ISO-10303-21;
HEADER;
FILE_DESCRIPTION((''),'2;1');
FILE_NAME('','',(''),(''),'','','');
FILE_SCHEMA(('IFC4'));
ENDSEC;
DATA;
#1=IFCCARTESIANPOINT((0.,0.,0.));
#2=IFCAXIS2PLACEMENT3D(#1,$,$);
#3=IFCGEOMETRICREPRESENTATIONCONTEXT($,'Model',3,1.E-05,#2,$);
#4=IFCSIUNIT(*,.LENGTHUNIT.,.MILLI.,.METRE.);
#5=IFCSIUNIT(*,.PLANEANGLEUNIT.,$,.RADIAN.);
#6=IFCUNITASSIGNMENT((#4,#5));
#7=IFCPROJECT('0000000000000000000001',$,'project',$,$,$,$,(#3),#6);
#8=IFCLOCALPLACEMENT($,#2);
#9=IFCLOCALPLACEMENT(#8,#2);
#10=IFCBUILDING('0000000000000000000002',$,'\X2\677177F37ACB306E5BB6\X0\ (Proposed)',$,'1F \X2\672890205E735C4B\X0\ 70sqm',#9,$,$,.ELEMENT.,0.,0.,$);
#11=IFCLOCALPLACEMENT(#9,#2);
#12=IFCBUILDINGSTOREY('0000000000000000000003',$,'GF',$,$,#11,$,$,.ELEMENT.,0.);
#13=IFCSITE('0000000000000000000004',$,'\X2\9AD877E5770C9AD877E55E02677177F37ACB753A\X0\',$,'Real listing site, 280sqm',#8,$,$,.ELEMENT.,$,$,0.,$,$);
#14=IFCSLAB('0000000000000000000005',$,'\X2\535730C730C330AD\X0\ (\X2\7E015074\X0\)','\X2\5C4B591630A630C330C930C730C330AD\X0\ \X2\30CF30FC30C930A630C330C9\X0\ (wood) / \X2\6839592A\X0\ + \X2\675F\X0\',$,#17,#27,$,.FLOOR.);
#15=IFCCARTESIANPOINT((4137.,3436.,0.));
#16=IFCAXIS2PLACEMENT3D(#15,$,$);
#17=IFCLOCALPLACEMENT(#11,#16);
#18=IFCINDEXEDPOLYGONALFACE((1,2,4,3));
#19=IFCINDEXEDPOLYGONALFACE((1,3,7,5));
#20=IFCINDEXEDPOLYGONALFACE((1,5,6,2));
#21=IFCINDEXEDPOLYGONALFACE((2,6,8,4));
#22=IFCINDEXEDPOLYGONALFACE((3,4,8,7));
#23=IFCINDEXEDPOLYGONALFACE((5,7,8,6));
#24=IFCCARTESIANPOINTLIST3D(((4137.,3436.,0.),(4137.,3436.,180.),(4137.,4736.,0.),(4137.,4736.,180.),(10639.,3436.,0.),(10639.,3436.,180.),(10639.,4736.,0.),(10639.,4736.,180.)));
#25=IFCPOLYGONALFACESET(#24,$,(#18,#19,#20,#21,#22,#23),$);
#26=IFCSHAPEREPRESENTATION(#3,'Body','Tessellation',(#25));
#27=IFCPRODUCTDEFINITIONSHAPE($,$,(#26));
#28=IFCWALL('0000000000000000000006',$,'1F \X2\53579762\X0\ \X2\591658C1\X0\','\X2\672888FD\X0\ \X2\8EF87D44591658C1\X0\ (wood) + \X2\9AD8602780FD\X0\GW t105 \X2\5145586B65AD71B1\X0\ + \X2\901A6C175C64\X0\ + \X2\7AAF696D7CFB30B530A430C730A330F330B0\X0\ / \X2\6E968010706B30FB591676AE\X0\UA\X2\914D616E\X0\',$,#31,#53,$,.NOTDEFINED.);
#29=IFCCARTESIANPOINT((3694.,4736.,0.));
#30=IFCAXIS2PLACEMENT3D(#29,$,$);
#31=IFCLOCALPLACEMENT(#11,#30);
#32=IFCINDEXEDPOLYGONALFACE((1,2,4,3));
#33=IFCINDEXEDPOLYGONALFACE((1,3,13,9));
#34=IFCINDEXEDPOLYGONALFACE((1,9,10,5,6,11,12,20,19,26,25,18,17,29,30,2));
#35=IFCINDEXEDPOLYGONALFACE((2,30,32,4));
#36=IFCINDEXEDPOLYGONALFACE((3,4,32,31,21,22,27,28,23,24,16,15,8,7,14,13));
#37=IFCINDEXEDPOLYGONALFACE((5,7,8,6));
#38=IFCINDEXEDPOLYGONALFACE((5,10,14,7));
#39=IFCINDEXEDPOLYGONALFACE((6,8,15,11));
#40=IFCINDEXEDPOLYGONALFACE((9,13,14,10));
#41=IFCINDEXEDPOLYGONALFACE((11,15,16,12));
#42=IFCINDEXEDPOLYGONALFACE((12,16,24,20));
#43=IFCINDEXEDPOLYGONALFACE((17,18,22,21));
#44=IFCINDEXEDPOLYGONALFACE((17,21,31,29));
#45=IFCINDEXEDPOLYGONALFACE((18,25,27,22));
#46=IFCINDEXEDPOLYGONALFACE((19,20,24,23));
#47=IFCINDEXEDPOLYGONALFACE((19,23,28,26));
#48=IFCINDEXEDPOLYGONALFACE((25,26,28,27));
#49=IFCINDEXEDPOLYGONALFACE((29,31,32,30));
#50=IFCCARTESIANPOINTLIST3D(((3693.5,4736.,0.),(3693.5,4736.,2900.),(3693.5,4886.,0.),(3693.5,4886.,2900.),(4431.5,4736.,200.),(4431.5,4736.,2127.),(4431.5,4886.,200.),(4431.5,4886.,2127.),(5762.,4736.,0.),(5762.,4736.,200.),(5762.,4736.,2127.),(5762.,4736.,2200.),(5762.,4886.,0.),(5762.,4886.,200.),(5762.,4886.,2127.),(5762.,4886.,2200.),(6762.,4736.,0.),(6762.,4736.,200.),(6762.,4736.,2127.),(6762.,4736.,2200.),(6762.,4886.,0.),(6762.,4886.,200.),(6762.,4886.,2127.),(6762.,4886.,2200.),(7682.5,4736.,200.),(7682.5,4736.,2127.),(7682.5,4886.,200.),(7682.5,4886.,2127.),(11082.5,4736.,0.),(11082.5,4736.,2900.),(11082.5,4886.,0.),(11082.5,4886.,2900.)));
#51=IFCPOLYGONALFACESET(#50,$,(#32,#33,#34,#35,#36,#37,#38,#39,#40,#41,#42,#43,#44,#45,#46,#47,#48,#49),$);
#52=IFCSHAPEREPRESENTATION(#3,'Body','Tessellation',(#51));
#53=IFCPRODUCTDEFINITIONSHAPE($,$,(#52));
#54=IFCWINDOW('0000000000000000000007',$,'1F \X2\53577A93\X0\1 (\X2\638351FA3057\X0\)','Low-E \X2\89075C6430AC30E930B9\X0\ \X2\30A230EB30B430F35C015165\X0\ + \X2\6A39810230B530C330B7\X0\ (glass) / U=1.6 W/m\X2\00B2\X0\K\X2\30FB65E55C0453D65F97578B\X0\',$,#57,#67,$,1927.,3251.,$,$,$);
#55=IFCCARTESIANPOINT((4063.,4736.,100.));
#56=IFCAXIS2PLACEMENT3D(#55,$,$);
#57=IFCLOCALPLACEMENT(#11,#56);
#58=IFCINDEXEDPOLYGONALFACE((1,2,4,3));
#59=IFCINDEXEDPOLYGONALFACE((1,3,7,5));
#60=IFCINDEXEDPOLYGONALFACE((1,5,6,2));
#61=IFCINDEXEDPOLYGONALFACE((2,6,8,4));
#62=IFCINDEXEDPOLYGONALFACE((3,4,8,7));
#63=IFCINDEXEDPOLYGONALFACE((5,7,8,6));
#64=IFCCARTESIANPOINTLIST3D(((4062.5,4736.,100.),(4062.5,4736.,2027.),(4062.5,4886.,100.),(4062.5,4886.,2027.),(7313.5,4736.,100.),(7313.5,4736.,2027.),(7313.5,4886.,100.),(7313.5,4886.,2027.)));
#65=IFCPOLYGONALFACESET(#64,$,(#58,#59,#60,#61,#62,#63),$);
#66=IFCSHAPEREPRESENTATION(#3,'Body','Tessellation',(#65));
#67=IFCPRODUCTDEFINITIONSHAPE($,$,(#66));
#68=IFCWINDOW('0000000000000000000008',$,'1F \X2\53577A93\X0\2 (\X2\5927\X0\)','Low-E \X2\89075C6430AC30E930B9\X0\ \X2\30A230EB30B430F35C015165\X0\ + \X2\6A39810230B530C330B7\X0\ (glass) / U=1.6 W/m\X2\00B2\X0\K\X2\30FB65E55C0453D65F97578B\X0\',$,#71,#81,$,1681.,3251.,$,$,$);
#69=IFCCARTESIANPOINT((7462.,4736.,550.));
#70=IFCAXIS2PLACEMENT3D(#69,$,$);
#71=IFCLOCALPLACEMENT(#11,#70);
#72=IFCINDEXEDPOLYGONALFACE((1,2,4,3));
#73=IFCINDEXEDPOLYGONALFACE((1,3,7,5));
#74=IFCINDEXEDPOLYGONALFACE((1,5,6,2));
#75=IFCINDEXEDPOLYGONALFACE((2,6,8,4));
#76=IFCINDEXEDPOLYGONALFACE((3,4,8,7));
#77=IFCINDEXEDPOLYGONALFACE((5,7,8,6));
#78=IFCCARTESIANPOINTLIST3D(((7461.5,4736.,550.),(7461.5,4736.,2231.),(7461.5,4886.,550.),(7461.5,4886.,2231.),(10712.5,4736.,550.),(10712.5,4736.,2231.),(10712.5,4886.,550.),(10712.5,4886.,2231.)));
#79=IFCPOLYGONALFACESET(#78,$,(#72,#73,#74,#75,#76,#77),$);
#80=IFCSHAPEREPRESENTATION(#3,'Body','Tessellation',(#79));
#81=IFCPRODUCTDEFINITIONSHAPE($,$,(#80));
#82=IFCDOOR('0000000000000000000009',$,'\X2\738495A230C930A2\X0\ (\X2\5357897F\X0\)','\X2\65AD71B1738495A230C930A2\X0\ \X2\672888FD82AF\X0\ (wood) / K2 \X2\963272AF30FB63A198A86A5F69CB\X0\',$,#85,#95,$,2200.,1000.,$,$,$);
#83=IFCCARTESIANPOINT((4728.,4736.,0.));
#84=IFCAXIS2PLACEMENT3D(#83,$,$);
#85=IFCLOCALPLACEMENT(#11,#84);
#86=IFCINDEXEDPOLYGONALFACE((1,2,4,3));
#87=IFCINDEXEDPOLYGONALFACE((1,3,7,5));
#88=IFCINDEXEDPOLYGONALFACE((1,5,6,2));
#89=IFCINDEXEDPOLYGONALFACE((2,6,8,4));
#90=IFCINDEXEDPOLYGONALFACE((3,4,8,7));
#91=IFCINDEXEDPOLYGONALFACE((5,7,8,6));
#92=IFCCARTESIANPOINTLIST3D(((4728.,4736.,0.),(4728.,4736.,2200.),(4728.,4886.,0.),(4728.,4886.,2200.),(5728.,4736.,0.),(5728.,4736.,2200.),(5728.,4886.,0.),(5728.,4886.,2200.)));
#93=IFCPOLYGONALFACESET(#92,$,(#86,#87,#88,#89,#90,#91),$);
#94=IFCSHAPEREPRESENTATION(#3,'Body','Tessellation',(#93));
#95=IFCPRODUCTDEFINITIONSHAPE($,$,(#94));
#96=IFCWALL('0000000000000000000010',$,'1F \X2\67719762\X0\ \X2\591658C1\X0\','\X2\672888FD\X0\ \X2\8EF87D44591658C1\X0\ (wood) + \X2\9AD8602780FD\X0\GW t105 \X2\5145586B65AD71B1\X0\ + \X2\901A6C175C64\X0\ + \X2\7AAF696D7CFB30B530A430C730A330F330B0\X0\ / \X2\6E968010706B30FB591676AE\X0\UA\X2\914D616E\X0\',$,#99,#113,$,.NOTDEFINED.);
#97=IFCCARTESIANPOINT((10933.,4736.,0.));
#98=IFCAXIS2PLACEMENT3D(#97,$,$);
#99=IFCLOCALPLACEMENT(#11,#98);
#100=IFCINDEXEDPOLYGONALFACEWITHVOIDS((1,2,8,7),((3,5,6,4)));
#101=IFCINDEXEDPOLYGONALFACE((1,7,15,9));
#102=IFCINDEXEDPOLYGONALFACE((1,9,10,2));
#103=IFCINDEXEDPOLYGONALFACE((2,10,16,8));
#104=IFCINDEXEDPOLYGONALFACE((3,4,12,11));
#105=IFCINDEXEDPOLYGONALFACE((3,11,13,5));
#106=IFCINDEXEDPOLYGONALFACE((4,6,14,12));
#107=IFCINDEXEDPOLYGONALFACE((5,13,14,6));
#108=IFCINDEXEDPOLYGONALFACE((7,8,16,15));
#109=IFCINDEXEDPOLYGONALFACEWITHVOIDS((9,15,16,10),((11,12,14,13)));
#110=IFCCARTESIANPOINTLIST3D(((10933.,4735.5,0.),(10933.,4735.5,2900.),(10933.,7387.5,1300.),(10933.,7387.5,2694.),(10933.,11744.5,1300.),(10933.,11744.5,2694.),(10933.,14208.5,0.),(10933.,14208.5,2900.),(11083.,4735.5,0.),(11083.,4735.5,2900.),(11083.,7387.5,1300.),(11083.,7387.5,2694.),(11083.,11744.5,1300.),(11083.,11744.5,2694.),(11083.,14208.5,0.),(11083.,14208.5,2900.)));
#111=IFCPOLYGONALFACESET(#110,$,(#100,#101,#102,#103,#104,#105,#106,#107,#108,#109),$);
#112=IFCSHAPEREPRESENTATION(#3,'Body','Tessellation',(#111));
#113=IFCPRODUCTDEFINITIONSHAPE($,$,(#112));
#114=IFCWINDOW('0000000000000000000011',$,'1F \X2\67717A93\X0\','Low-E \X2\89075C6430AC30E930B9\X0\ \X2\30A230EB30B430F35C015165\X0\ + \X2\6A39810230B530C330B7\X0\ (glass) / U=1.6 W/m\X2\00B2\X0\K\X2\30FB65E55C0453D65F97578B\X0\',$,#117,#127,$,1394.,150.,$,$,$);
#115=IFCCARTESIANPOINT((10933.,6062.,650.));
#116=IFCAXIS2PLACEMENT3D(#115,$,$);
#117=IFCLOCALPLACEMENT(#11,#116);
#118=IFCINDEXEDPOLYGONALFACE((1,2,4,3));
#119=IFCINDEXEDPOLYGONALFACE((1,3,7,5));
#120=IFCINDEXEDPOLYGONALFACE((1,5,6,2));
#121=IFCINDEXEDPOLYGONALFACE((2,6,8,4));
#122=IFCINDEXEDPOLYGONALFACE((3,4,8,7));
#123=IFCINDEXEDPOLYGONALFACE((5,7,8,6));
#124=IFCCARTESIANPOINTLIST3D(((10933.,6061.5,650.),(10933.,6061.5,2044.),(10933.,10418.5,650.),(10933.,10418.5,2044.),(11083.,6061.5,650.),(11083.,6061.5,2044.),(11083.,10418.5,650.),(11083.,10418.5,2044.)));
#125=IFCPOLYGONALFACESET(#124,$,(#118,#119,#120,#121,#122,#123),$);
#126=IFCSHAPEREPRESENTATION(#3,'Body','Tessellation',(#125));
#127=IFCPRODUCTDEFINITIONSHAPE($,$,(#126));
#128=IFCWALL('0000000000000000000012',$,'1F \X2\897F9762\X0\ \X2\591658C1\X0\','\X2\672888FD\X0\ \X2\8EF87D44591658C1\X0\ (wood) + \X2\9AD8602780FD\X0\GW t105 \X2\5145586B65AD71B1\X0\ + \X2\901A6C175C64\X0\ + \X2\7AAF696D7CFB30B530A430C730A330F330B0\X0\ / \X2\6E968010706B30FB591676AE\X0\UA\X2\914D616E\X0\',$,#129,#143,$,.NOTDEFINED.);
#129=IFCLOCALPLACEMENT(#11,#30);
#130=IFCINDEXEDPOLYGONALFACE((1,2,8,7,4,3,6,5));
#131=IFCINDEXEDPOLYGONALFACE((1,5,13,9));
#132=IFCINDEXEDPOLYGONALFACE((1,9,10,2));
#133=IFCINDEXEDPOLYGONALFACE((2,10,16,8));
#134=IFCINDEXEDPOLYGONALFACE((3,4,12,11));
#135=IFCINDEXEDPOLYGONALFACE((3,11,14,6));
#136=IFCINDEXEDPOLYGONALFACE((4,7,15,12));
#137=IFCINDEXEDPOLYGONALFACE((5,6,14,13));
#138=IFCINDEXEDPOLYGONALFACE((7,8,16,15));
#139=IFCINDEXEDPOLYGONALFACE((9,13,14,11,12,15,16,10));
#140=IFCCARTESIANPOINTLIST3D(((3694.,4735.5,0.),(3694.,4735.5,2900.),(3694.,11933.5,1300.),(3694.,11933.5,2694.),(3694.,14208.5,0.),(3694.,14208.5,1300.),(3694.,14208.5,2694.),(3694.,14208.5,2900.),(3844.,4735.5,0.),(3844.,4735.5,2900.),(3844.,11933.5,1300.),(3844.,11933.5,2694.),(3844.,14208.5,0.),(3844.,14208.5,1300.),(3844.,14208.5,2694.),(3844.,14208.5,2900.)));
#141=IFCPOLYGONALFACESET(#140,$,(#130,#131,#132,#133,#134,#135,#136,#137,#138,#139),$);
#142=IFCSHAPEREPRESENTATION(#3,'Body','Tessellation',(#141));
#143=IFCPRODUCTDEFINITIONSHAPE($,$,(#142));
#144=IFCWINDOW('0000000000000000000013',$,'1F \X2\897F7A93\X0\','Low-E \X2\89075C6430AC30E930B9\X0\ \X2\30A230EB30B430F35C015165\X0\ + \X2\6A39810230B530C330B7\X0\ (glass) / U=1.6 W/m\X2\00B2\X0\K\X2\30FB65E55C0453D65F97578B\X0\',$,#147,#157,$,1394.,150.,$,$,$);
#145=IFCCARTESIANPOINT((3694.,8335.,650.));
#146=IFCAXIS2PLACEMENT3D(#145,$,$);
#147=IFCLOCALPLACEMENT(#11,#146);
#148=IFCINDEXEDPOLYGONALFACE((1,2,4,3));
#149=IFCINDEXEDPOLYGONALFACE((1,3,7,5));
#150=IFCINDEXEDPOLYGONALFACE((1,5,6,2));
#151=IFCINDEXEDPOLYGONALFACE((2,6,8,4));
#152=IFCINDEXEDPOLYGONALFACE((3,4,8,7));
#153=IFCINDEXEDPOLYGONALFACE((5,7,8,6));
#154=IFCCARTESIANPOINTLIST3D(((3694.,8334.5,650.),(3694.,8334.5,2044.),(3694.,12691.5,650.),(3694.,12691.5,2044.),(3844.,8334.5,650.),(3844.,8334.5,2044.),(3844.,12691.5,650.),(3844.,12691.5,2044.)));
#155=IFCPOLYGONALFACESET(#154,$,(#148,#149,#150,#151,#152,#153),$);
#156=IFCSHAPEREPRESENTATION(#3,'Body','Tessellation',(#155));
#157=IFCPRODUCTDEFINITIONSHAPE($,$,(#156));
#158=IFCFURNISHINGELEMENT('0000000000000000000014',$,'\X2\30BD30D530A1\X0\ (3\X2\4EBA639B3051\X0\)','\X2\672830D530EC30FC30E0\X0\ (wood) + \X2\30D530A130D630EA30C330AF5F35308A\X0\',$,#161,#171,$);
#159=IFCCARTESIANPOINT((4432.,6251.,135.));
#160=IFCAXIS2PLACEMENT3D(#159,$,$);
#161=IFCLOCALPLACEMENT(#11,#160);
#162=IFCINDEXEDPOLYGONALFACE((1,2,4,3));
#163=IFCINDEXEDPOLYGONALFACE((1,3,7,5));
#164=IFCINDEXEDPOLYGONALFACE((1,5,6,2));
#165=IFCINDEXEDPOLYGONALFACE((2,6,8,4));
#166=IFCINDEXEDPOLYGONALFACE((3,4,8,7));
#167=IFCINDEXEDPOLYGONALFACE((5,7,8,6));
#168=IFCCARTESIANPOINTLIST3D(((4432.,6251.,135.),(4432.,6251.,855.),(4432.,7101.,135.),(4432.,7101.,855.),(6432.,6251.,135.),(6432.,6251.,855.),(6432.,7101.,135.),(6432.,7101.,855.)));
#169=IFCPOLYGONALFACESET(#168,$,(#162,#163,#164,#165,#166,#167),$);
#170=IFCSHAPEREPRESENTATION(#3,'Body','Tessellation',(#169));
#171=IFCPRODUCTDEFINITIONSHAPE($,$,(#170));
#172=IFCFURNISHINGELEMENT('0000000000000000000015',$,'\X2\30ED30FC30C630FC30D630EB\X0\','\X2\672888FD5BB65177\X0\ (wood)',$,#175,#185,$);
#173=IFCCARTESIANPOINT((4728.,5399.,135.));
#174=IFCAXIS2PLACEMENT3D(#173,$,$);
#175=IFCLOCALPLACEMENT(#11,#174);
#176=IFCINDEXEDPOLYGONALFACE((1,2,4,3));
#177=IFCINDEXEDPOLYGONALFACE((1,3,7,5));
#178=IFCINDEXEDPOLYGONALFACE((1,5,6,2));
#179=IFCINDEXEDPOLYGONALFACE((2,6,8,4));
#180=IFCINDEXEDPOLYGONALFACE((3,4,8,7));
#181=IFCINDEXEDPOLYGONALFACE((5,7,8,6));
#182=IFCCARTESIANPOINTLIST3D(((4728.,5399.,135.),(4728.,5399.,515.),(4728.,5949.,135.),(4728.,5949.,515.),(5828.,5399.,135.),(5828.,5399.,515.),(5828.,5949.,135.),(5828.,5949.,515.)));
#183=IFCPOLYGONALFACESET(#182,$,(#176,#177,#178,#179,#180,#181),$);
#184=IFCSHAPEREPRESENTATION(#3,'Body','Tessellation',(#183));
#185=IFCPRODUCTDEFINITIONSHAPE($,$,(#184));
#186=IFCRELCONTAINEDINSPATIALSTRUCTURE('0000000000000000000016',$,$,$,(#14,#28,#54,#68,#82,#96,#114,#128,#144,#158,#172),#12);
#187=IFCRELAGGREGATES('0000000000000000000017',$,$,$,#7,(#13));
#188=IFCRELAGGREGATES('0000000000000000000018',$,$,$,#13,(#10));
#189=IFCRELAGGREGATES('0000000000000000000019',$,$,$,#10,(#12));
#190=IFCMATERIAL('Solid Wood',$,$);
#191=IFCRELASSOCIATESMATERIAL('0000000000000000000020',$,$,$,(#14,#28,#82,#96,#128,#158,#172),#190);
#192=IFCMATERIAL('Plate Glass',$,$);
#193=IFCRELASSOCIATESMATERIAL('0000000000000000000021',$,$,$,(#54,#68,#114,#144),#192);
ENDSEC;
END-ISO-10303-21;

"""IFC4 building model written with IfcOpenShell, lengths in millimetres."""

from ifc_helpers import new_model, si_unit, frame, frame_2d, origin, place, context, project, spatial, rectangle, extrude, material, element, fill, save


model = new_model("IFC4")

# Units and contexts
model_context = context("Model", 3, precision=1e-05, world=origin())
ifc_project = project(units=[si_unit("LENGTHUNIT", "METRE", prefix="MILLI"), si_unit("PLANEANGLEUNIT", "RADIAN")], contexts=[model_context])

# Site, building, storey
site_placement = place(None, origin())
site = spatial("IfcSite", under=ifc_project, at=site_placement, Name="高知県高知市東石立町", ObjectType="Real listing site, 280sqm", CompositionType="ELEMENT", RefElevation=0.0)
building_placement = place(site_placement, origin())
building = spatial("IfcBuilding", under=site, at=building_placement, Name="東石立の家 (Proposed)", ObjectType="1F 木造平屋 70sqm", CompositionType="ELEMENT", ElevationOfRefHeight=0.0, ElevationOfTerrain=0.0)
storey_placement = place(building_placement, origin())
storey = spatial("IfcBuildingStorey", under=building, at=storey_placement, Name="GF", CompositionType="ELEMENT", Elevation=0.0)

# Slab
ifc_material_1 = material(Name="Solid Wood")
slab_1_placement = place(storey_placement, frame((4137.0, 3436.0, 0.0)))
element("IfcSlab", 1, at=slab_1_placement, inside=storey, material=ifc_material_1, Name="南デッキ (縁側)", Description="屋外ウッドデッキ ハードウッド (wood) / 根太 + 束", PredefinedType="FLOOR", context=model_context, shape_type="SweptSolid", body=[
    extrude(rectangle(XDim=6502.0, YDim=1300.0, at=frame_2d((3251.0, 650.0))), frame((4137.0, 3436.0, 0.0)), (0.0, 0.0, 1.0), 180.0),
])

# Wall, openings, windows, door
wall_1_placement = place(storey_placement, frame((3694.0, 4736.0, 0.0)))
wall_1 = element("IfcWall", 2, at=wall_1_placement, inside=storey, material=ifc_material_1, Name="1F 南面 外壁", Description="木製 軸組外壁 (wood) + 高性能GW t105 充填断熱 + 通気層 + 窯業系サイディング / 準耐火・外皮UA配慮", PredefinedType="NOTDEFINED", context=model_context, shape_type="SweptSolid", body=[
    extrude(rectangle(XDim=7389.0, YDim=150.0, at=frame_2d((3694.0, 75.0))), frame((3694.0, 4736.0, 0.0)), (0.0, 0.0, 1.0), 2900.0),
])
opening_1_placement = place(storey_placement, frame((4063.0, 4736.0, 100.0)))
opening_1 = element("IfcOpeningElement", 3, at=opening_1_placement, cuts=wall_1, PredefinedType="NOTDEFINED", context=model_context, shape_type="SweptSolid", body=[
    extrude(rectangle(XDim=3251.0, YDim=150.0, at=frame_2d((1625.0, 75.0))), frame((4063.0, 4736.0, 100.0)), (0.0, 0.0, 1.0), 1927.0),
])
opening_2_placement = place(storey_placement, frame((7462.0, 4736.0, 550.0)))
opening_2 = element("IfcOpeningElement", 4, at=opening_2_placement, cuts=wall_1, PredefinedType="NOTDEFINED", context=model_context, shape_type="SweptSolid", body=[
    extrude(rectangle(XDim=3251.0, YDim=150.0, at=frame_2d((1625.0, 75.0))), frame((7462.0, 4736.0, 550.0)), (0.0, 0.0, 1.0), 1681.0),
])
opening_3_placement = place(storey_placement, frame((4728.0, 4736.0, 0.0)))
opening_3 = element("IfcOpeningElement", 5, at=opening_3_placement, cuts=wall_1, PredefinedType="NOTDEFINED", context=model_context, shape_type="SweptSolid", body=[
    extrude(rectangle(XDim=1000.0, YDim=150.0, at=frame_2d((500.0, 75.0))), frame((4728.0, 4736.0, 0.0)), (0.0, 0.0, 1.0), 2200.0),
])
ifc_material_2 = material(Name="Plate Glass")
window_1_placement = place(storey_placement, frame((4063.0, 4736.0, 100.0)))
window_1 = element("IfcWindow", 6, at=window_1_placement, inside=storey, material=ifc_material_2, Name="1F 南窓1 (掃出し)", Description="Low-E 複層ガラス アルゴン封入 + 樹脂サッシ (glass) / U=1.6 W/m²K・日射取得型", OverallHeight=1927.0, OverallWidth=3251.0, context=model_context, shape_type="SweptSolid", body=[
    extrude(rectangle(XDim=3251.0, YDim=150.0, at=frame_2d((1625.0, 75.0))), frame((4063.0, 4736.0, 100.0)), (0.0, 0.0, 1.0), 1927.0),
])
fill(opening_1, window_1)
window_2_placement = place(storey_placement, frame((7462.0, 4736.0, 550.0)))
window_2 = element("IfcWindow", 7, at=window_2_placement, inside=storey, material=ifc_material_2, Name="1F 南窓2 (大)", Description="Low-E 複層ガラス アルゴン封入 + 樹脂サッシ (glass) / U=1.6 W/m²K・日射取得型", OverallHeight=1681.0, OverallWidth=3251.0, context=model_context, shape_type="SweptSolid", body=[
    extrude(rectangle(XDim=3251.0, YDim=150.0, at=frame_2d((1625.0, 75.0))), frame((7462.0, 4736.0, 550.0)), (0.0, 0.0, 1.0), 1681.0),
])
fill(opening_2, window_2)
door_placement = place(storey_placement, frame((4728.0, 4736.0, 0.0)))
door = element("IfcDoor", 8, at=door_placement, inside=storey, material=ifc_material_1, Name="玄関ドア (南西)", Description="断熱玄関ドア 木製芯 (wood) / K2 防犯・採風機構", OverallHeight=2200.0, OverallWidth=1000.0, context=model_context, shape_type="SweptSolid", body=[
    extrude(rectangle(XDim=1000.0, YDim=150.0, at=frame_2d((500.0, 75.0))), frame((4728.0, 4736.0, 0.0)), (0.0, 0.0, 1.0), 2200.0),
])
fill(opening_3, door)

# Walls, openings, windows
wall_2_placement = place(storey_placement, frame((10933.0, 4736.0, 0.0)))
wall_2 = element("IfcWall", 9, at=wall_2_placement, inside=storey, material=ifc_material_1, Name="1F 東面 外壁", Description="木製 軸組外壁 (wood) + 高性能GW t105 充填断熱 + 通気層 + 窯業系サイディング / 準耐火・外皮UA配慮", PredefinedType="NOTDEFINED", context=model_context, shape_type="SweptSolid", body=[
    extrude(rectangle(XDim=150.0, YDim=9473.0, at=frame_2d((75.0, 4736.0))), frame((10933.0, 4736.0, 0.0)), (0.0, 0.0, 1.0), 2900.0),
])
opening_4_placement = place(storey_placement, frame((10933.0, 6062.0, 650.0)))
opening_4 = element("IfcOpeningElement", 10, at=opening_4_placement, cuts=wall_2, PredefinedType="NOTDEFINED", context=model_context, shape_type="SweptSolid", body=[
    extrude(rectangle(XDim=150.0, YDim=4357.0, at=frame_2d((75.0, 2178.0))), frame((10933.0, 6062.0, 650.0)), (0.0, 0.0, 1.0), 1394.0),
])
window_3_placement = place(storey_placement, frame((10933.0, 6062.0, 650.0)))
window_3 = element("IfcWindow", 11, at=window_3_placement, inside=storey, material=ifc_material_2, Name="1F 東窓", Description="Low-E 複層ガラス アルゴン封入 + 樹脂サッシ (glass) / U=1.6 W/m²K・日射取得型", OverallHeight=1394.0, OverallWidth=150.0, context=model_context, shape_type="SweptSolid", body=[
    extrude(rectangle(XDim=150.0, YDim=4357.0, at=frame_2d((75.0, 2178.0))), frame((10933.0, 6062.0, 650.0)), (0.0, 0.0, 1.0), 1394.0),
])
fill(opening_4, window_3)
wall_3_placement = place(storey_placement, frame((3694.0, 4736.0, 0.0)))
wall_3 = element("IfcWall", 12, at=wall_3_placement, inside=storey, material=ifc_material_1, Name="1F 西面 外壁", Description="木製 軸組外壁 (wood) + 高性能GW t105 充填断熱 + 通気層 + 窯業系サイディング / 準耐火・外皮UA配慮", PredefinedType="NOTDEFINED", context=model_context, shape_type="SweptSolid", body=[
    extrude(rectangle(XDim=150.0, YDim=9473.0, at=frame_2d((75.0, 4736.0))), frame((3694.0, 4736.0, 0.0)), (0.0, 0.0, 1.0), 2900.0),
])
opening_5_placement = place(storey_placement, frame((3694.0, 8335.0, 650.0)))
opening_5 = element("IfcOpeningElement", 13, at=opening_5_placement, cuts=wall_3, PredefinedType="NOTDEFINED", context=model_context, shape_type="SweptSolid", body=[
    extrude(rectangle(XDim=150.0, YDim=4357.0, at=frame_2d((75.0, 2178.0))), frame((3694.0, 8335.0, 650.0)), (0.0, 0.0, 1.0), 1394.0),
])
window_4_placement = place(storey_placement, frame((3694.0, 8335.0, 650.0)))
window_4 = element("IfcWindow", 14, at=window_4_placement, inside=storey, material=ifc_material_2, Name="1F 西窓", Description="Low-E 複層ガラス アルゴン封入 + 樹脂サッシ (glass) / U=1.6 W/m²K・日射取得型", OverallHeight=1394.0, OverallWidth=150.0, context=model_context, shape_type="SweptSolid", body=[
    extrude(rectangle(XDim=150.0, YDim=4357.0, at=frame_2d((75.0, 2178.0))), frame((3694.0, 8335.0, 650.0)), (0.0, 0.0, 1.0), 1394.0),
])
fill(opening_5, window_4)

# Furnishing elements
furnishing_1_placement = place(storey_placement, frame((4432.0, 6251.0, 135.0)))
element("IfcFurnishingElement", 15, at=furnishing_1_placement, inside=storey, material=ifc_material_1, Name="ソファ (3人掛け)", Description="木フレーム (wood) + ファブリック張り", context=model_context, shape_type="SweptSolid", body=[
    extrude(rectangle(XDim=2000.0, YDim=850.0, at=frame_2d((1000.0, 425.0))), frame((4432.0, 6251.0, 135.0)), (0.0, 0.0, 1.0), 720.0),
])
furnishing_2_placement = place(storey_placement, frame((4728.0, 5399.0, 135.0)))
element("IfcFurnishingElement", 16, at=furnishing_2_placement, inside=storey, material=ifc_material_1, Name="ローテーブル", Description="木製家具 (wood)", context=model_context, shape_type="SweptSolid", body=[
    extrude(rectangle(XDim=1100.0, YDim=550.0, at=frame_2d((550.0, 275.0))), frame((4728.0, 5399.0, 135.0)), (0.0, 0.0, 1.0), 380.0),
])

save(model, "model.ifc")
